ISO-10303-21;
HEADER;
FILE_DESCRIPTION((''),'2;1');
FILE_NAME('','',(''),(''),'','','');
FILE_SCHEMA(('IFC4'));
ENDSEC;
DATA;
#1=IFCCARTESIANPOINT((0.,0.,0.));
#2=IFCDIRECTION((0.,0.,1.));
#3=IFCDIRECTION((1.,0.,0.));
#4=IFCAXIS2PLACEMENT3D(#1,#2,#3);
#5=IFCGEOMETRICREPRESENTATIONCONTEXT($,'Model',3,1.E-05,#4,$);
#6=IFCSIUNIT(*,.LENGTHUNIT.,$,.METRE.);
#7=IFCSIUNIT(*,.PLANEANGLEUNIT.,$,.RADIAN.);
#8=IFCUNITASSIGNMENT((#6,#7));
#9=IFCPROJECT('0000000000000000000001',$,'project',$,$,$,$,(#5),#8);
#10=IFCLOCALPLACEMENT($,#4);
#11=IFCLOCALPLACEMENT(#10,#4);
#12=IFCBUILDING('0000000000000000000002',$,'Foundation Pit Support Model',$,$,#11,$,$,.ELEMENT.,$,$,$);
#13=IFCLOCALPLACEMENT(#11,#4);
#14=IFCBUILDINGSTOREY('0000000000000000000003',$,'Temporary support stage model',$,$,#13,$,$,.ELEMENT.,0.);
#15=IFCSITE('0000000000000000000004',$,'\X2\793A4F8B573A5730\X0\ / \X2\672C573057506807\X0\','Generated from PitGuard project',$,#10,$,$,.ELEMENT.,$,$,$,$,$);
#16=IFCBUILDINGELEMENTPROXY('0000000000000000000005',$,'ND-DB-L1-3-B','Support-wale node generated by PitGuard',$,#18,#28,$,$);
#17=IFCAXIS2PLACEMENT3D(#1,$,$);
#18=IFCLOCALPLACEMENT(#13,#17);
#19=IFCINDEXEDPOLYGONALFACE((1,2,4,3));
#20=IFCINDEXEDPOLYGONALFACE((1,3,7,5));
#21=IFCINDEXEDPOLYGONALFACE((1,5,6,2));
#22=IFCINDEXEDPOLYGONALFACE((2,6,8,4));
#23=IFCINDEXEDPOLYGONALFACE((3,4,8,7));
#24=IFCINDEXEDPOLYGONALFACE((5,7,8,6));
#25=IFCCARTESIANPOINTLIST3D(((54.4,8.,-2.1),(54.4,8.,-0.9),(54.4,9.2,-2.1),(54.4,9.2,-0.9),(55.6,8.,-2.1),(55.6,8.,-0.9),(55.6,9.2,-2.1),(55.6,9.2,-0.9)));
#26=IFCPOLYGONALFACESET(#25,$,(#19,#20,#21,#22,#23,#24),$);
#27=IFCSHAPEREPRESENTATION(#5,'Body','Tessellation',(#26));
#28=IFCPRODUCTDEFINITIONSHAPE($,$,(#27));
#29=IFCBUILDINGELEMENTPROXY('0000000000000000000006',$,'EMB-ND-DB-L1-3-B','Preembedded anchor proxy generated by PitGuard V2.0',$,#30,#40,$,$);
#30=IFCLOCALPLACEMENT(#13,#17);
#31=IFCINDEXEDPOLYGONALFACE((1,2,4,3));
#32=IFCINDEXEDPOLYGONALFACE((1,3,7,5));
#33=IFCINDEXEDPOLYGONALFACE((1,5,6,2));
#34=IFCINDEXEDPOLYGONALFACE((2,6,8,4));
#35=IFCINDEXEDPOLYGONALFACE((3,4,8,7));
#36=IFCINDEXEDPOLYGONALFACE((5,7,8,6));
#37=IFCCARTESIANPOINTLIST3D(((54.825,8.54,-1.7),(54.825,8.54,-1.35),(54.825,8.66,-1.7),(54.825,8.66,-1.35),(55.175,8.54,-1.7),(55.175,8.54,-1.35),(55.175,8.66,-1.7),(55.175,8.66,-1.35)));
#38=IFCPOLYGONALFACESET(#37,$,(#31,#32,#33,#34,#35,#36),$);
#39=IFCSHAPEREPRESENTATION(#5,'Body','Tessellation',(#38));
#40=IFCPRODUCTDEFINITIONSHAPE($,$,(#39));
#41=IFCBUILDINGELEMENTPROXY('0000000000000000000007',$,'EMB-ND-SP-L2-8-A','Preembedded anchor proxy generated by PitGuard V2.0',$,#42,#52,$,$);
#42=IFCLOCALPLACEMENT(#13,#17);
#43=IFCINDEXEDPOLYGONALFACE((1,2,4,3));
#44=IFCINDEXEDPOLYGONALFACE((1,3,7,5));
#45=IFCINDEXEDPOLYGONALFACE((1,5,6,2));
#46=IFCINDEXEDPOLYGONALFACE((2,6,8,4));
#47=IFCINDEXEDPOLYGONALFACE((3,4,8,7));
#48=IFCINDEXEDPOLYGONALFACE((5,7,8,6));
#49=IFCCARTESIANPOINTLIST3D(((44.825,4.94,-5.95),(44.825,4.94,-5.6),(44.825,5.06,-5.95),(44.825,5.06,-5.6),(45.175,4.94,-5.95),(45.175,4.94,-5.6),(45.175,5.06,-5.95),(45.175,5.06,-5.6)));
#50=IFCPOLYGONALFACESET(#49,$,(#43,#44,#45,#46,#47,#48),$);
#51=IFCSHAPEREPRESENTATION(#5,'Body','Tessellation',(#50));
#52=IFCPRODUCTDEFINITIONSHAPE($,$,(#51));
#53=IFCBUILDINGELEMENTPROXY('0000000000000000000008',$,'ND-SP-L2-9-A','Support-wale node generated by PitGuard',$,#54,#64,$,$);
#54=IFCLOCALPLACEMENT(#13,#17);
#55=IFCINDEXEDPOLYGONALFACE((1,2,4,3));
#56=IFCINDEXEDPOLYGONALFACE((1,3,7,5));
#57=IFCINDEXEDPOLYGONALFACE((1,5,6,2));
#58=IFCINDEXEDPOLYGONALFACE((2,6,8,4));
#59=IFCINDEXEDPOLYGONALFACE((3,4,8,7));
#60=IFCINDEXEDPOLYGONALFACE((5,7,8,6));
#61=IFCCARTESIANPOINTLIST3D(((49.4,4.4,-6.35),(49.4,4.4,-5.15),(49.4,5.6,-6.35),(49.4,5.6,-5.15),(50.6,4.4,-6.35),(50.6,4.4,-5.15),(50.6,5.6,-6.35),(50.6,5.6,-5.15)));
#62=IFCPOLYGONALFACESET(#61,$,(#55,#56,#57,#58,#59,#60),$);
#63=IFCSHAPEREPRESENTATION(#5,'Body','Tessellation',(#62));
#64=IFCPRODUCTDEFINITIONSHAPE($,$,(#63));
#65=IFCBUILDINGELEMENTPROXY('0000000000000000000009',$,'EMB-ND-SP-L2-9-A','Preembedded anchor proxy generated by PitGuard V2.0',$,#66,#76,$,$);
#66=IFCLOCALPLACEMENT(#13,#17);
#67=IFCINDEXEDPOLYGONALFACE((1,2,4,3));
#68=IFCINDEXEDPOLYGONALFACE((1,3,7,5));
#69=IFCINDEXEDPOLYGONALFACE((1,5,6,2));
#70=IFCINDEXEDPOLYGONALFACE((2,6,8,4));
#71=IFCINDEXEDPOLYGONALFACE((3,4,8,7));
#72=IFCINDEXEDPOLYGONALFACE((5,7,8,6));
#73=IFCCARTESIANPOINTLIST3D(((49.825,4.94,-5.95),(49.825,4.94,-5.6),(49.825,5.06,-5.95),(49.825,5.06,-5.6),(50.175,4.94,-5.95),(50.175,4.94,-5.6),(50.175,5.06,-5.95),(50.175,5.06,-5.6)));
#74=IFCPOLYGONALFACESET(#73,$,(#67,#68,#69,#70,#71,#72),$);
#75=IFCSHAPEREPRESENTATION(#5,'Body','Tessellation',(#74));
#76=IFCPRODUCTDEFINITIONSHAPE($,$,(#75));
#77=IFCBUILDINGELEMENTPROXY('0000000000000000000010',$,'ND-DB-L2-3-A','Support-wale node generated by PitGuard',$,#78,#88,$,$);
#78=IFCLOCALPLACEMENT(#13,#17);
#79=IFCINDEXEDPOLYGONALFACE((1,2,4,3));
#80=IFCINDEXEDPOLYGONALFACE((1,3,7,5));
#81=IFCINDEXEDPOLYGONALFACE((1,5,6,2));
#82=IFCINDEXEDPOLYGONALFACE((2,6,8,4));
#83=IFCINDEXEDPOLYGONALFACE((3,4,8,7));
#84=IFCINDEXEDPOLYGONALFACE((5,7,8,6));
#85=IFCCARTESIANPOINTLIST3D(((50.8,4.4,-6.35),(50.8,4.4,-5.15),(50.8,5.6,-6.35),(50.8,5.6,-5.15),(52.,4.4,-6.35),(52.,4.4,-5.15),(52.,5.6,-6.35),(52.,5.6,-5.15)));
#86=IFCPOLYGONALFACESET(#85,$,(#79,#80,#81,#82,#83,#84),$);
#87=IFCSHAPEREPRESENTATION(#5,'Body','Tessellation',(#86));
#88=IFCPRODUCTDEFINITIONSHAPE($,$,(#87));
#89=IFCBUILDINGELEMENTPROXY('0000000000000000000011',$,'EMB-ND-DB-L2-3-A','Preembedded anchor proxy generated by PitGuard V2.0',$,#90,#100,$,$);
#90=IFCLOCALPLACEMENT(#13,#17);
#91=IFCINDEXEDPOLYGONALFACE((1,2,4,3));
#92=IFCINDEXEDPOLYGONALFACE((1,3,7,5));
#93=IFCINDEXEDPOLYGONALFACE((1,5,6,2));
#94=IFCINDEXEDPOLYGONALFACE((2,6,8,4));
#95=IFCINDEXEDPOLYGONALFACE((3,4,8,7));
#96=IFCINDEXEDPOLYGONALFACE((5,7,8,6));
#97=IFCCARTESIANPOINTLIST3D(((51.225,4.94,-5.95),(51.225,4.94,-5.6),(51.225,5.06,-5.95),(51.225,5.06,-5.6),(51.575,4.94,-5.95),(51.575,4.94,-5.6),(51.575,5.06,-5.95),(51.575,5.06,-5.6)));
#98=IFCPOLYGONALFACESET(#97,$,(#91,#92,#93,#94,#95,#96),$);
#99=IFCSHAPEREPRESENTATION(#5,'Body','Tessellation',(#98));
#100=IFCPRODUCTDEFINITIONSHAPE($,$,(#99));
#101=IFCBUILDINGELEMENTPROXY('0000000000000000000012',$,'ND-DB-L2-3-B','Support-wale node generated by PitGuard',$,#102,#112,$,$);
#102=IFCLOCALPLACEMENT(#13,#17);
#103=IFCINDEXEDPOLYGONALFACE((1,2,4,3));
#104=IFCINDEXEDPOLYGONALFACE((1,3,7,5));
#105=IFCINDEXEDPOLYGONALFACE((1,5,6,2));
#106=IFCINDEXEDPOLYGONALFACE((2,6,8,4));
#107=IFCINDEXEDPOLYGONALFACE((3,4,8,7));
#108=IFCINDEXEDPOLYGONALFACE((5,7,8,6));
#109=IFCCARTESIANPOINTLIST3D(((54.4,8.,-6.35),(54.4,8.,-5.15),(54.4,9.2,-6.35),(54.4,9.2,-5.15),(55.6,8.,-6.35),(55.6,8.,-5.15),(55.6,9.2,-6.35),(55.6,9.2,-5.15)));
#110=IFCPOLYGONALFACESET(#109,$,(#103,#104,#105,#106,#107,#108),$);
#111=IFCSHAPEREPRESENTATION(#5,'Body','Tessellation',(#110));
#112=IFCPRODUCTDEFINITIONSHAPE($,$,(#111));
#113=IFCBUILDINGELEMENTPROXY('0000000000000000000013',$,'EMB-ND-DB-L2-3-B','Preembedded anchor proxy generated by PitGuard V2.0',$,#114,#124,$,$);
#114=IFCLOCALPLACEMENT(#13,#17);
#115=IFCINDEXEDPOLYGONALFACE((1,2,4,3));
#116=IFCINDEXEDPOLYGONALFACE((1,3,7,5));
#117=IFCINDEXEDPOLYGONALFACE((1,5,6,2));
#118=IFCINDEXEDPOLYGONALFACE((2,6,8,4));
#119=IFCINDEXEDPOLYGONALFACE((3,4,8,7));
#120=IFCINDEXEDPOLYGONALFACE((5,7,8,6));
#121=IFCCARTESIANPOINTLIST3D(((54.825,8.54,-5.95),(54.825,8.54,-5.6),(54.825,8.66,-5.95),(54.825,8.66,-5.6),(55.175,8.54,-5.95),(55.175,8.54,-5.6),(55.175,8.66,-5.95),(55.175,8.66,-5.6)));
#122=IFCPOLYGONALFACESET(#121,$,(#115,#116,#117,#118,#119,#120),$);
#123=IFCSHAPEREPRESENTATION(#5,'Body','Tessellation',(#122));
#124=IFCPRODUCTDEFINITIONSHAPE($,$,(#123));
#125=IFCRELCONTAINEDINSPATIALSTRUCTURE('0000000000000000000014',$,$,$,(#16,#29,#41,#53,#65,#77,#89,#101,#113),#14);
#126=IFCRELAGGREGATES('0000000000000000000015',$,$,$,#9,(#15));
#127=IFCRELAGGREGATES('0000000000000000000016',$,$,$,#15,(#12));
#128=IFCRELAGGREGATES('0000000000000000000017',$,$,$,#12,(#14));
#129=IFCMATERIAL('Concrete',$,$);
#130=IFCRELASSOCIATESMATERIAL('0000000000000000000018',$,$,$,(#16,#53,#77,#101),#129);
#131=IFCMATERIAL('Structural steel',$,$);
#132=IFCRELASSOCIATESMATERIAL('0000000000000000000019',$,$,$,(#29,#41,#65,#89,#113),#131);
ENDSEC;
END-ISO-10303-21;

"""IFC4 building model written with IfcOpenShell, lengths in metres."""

from ifc_helpers import new_model, si_unit, frame, origin_with_axes, origin_2d, place, context, project, spatial, rectangle, extrude, material, element, save


model = new_model("IFC4")

# Units and contexts
model_context = context("Model", 3, precision=1e-05, world=origin_with_axes())
ifc_project = project(units=[si_unit("LENGTHUNIT", "METRE"), si_unit("PLANEANGLEUNIT", "RADIAN")], contexts=[model_context])

# Site, building, storey
site_placement = place(None, origin_with_axes())
site = spatial("IfcSite", under=ifc_project, at=site_placement, Name="示例场地 / 本地坐标", Description="Generated from PitGuard project", CompositionType="ELEMENT")
building_placement = place(site_placement, origin_with_axes())
building = spatial("IfcBuilding", under=site, at=building_placement, Name="Foundation Pit Support Model", CompositionType="ELEMENT")
storey_placement = place(building_placement, origin_with_axes())
storey = spatial("IfcBuildingStorey", under=building, at=storey_placement, Name="Temporary support stage model", CompositionType="ELEMENT", Elevation=0.0)

# Shared definitions
ifc_material_1 = material(Name="Concrete")

# Shared definitions
ifc_material_2 = material(Name="Structural steel")

# Building element proxies
proxy_1_placement = place(storey_placement, frame((55.0, 8.6, -2.1), z_axis=(0.0, 0.0, 1.0), x_axis=(1.0, 0.0, 0.0)))
element("IfcBuildingElementProxy", 1, at=proxy_1_placement, inside=storey, material=ifc_material_1, Name="ND-DB-L1-3-B", Description="Support-wale node generated by PitGuard", context=model_context, shape_type="SweptSolid", body=[
    extrude(rectangle(XDim=1.2, YDim=1.2, at=origin_2d()), origin_with_axes(), (0.0, 0.0, 1.0), 1.2),
])
for number, where, z_axis, x_axis, name in (
    (2, (55.0, 8.6, -1.7), (0.0, 0.0, 1.0), (1.0, 0.0, 0.0), "EMB-ND-DB-L1-3-B"),
    (3, (45.0, 5.0, -5.95), (0.0, 0.0, 1.0), (1.0, 0.0, 0.0), "EMB-ND-SP-L2-8-A"),
):
    element("IfcBuildingElementProxy", number, at=place(storey_placement, frame(where, z_axis=z_axis, x_axis=x_axis)), inside=storey, material=ifc_material_2, Name=name, Description="Preembedded anchor proxy generated by PitGuard V2.0", context=model_context, shape_type="SweptSolid", body=[
        extrude(rectangle(XDim=0.35, YDim=0.12, at=origin_2d()), origin_with_axes(), (0.0, 0.0, 1.0), 0.35),
    ])
proxy_2_placement = place(storey_placement, frame((50.0, 5.0, -6.35), z_axis=(0.0, 0.0, 1.0), x_axis=(1.0, 0.0, 0.0)))
element("IfcBuildingElementProxy", 4, at=proxy_2_placement, inside=storey, material=ifc_material_1, Name="ND-SP-L2-9-A", Description="Support-wale node generated by PitGuard", context=model_context, shape_type="SweptSolid", body=[
    extrude(rectangle(XDim=1.2, YDim=1.2, at=origin_2d()), origin_with_axes(), (0.0, 0.0, 1.0), 1.2),
])
proxy_3_placement = place(storey_placement, frame((50.0, 5.0, -5.95), z_axis=(0.0, 0.0, 1.0), x_axis=(1.0, 0.0, 0.0)))
element("IfcBuildingElementProxy", 5, at=proxy_3_placement, inside=storey, material=ifc_material_2, Name="EMB-ND-SP-L2-9-A", Description="Preembedded anchor proxy generated by PitGuard V2.0", context=model_context, shape_type="SweptSolid", body=[
    extrude(rectangle(XDim=0.35, YDim=0.12, at=origin_2d()), origin_with_axes(), (0.0, 0.0, 1.0), 0.35),
])
proxy_4_placement = place(storey_placement, frame((51.4, 5.0, -6.35), z_axis=(0.0, 0.0, 1.0), x_axis=(1.0, 0.0, 0.0)))
element("IfcBuildingElementProxy", 6, at=proxy_4_placement, inside=storey, material=ifc_material_1, Name="ND-DB-L2-3-A", Description="Support-wale node generated by PitGuard", context=model_context, shape_type="SweptSolid", body=[
    extrude(rectangle(XDim=1.2, YDim=1.2, at=origin_2d()), origin_with_axes(), (0.0, 0.0, 1.0), 1.2),
])
proxy_5_placement = place(storey_placement, frame((51.4, 5.0, -5.95), z_axis=(0.0, 0.0, 1.0), x_axis=(1.0, 0.0, 0.0)))
element("IfcBuildingElementProxy", 7, at=proxy_5_placement, inside=storey, material=ifc_material_2, Name="EMB-ND-DB-L2-3-A", Description="Preembedded anchor proxy generated by PitGuard V2.0", context=model_context, shape_type="SweptSolid", body=[
    extrude(rectangle(XDim=0.35, YDim=0.12, at=origin_2d()), origin_with_axes(), (0.0, 0.0, 1.0), 0.35),
])
proxy_6_placement = place(storey_placement, frame((55.0, 8.6, -6.35), z_axis=(0.0, 0.0, 1.0), x_axis=(1.0, 0.0, 0.0)))
element("IfcBuildingElementProxy", 8, at=proxy_6_placement, inside=storey, material=ifc_material_1, Name="ND-DB-L2-3-B", Description="Support-wale node generated by PitGuard", context=model_context, shape_type="SweptSolid", body=[
    extrude(rectangle(XDim=1.2, YDim=1.2, at=origin_2d()), origin_with_axes(), (0.0, 0.0, 1.0), 1.2),
])
proxy_7_placement = place(storey_placement, frame((55.0, 8.6, -5.95), z_axis=(0.0, 0.0, 1.0), x_axis=(1.0, 0.0, 0.0)))
element("IfcBuildingElementProxy", 9, at=proxy_7_placement, inside=storey, material=ifc_material_2, Name="EMB-ND-DB-L2-3-B", Description="Preembedded anchor proxy generated by PitGuard V2.0", context=model_context, shape_type="SweptSolid", body=[
    extrude(rectangle(XDim=0.35, YDim=0.12, at=origin_2d()), origin_with_axes(), (0.0, 0.0, 1.0), 0.35),
])

save(model, "model.ifc")
